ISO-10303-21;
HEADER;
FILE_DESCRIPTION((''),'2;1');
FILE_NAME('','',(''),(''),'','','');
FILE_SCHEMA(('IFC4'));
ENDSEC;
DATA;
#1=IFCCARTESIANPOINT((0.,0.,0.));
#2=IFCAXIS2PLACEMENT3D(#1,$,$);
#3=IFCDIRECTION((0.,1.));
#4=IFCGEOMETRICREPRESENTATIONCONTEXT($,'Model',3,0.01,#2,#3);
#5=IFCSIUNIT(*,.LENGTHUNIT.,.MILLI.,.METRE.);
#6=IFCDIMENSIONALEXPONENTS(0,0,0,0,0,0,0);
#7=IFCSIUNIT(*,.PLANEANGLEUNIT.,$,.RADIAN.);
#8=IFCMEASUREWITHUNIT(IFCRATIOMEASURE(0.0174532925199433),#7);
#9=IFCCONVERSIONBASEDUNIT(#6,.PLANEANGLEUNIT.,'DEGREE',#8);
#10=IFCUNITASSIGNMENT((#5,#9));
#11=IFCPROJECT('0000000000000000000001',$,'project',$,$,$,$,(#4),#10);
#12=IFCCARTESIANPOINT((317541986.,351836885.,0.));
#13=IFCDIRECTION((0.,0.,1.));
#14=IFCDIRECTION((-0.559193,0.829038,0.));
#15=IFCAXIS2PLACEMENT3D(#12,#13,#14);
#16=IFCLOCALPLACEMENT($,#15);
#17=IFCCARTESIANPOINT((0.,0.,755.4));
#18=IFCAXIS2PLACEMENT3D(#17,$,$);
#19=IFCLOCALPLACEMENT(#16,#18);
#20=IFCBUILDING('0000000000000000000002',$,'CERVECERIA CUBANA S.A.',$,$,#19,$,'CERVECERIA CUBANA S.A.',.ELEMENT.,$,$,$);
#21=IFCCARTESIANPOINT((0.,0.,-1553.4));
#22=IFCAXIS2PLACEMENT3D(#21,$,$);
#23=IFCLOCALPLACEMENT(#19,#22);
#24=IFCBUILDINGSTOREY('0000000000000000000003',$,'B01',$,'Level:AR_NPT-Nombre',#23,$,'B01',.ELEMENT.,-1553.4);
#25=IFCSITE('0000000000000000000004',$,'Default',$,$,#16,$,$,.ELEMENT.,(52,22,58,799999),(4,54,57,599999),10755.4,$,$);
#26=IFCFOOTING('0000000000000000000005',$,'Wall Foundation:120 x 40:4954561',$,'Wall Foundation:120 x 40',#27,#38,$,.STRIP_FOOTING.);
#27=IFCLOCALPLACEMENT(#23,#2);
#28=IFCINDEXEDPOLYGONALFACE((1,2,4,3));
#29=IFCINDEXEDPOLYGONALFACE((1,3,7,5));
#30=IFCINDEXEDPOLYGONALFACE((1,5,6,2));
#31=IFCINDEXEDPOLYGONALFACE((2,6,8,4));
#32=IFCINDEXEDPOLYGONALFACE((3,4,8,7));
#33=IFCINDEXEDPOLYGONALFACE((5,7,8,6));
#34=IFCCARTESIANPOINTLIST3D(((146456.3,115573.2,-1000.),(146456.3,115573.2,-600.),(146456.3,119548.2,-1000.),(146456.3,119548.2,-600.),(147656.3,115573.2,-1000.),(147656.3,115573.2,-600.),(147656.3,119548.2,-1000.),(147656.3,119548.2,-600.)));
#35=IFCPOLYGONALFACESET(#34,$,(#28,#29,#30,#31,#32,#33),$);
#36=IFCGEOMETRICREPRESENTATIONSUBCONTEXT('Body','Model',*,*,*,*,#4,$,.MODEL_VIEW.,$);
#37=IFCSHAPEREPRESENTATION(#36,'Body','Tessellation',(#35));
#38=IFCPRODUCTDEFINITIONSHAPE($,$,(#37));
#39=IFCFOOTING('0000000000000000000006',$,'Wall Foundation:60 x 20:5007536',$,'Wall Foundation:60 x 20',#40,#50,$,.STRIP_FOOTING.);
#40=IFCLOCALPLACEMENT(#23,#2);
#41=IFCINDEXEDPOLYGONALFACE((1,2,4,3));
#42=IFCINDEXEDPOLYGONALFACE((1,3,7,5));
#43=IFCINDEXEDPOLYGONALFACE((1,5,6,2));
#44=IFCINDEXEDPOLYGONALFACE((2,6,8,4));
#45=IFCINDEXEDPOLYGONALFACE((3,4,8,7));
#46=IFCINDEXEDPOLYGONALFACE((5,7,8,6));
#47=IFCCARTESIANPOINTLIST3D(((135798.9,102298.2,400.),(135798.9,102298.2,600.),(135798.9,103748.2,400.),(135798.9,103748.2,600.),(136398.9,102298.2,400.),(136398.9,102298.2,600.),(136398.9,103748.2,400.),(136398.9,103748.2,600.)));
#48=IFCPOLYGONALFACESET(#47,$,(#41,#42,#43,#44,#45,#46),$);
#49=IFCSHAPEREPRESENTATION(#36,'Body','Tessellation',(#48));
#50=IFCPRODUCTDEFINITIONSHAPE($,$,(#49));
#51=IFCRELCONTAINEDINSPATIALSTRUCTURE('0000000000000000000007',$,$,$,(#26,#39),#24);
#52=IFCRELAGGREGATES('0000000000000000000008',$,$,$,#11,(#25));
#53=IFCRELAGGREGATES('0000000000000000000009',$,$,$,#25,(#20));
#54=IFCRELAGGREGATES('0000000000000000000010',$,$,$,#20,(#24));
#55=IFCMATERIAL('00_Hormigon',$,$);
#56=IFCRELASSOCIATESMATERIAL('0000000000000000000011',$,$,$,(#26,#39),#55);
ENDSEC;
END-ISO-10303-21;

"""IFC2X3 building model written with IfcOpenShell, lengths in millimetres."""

from ifc_helpers import new_model, entity, si_unit, converted_unit, direction, frame, frame_2d, origin, origin_2d_with_axis, place, context, subcontext, project, spatial, rectangle, extrude, material, element, save


model = new_model("IFC2X3")

# Units and contexts
model_context = context("Model", 3, precision=0.01, world=origin(), true_north=direction((0.0, 1.0)))
body_context = subcontext(model_context, "Body", "Model", "MODEL_VIEW")
ifc_project = project(units=[si_unit("LENGTHUNIT", "METRE", prefix="MILLI"), converted_unit("PLANEANGLEUNIT", "DEGREE", entity("IfcRatioMeasure", 0.0174532925199433), si_unit("PLANEANGLEUNIT", "RADIAN"), dimensions=[0, 0, 0, 0, 0, 0, 0])], contexts=[model_context])

# Site, building, storey
site_placement = place(None, frame((317541986.0, 351836885.0, 0.0), z_axis=(0.0, 0.0, 1.0), x_axis=(-0.559193, 0.829038, 0.0)))
site = spatial("IfcSite", under=ifc_project, at=site_placement, Name="Default", CompositionType="ELEMENT", RefLatitude=(52, 22, 58, 799999), RefLongitude=(4, 54, 57, 599999), RefElevation=10755.4)
building_placement = place(site_placement, frame((0.0, 0.0, 755.4)))
building = spatial("IfcBuilding", under=site, at=building_placement, Name="CERVECERIA CUBANA S.A.", LongName="CERVECERIA CUBANA S.A.", CompositionType="ELEMENT")
storey_placement = place(building_placement, frame((0.0, 0.0, -1553.4)))
storey = spatial("IfcBuildingStorey", under=building, at=storey_placement, Name="B01", ObjectType="Level:AR_NPT-Nombre", LongName="B01", CompositionType="ELEMENT", Elevation=-1553.4)

# Footings
ifc_material = material(Name="00_Hormigon")
footing_1_placement = place(storey_placement, origin())
element("IfcFooting", 1, at=footing_1_placement, inside=storey, material=ifc_material, Name="Wall Foundation:120 x 40:4954561", ObjectType="Wall Foundation:120 x 40", PredefinedType="STRIP_FOOTING", context=body_context, shape_type="SweptSolid", body=[
    extrude(rectangle(XDim=3975.0, YDim=1200.0, at=frame_2d((0.0, 0.0), x_axis=(1.0, 0.0))), frame((147056.3, 117560.7, -1000.0), z_axis=(0.0, 0.0, 1.0), x_axis=(0.0, -1.0, 0.0)), (0.0, 0.0, 1.0), 400.0),
])
footing_2_placement = place(storey_placement, origin())
element("IfcFooting", 2, at=footing_2_placement, inside=storey, material=ifc_material, Name="Wall Foundation:60 x 20:5007536", ObjectType="Wall Foundation:60 x 20", PredefinedType="STRIP_FOOTING", context=body_context, shape_type="SweptSolid", body=[
    extrude(rectangle(XDim=1450.0, YDim=600.0, at=origin_2d_with_axis()), frame((136098.9, 103023.2, 400.0), z_axis=(0.0, 0.0, 1.0), x_axis=(0.0, -1.0, 0.0)), (0.0, 0.0, 1.0), 200.0),
])

save(model, "model.ifc")
